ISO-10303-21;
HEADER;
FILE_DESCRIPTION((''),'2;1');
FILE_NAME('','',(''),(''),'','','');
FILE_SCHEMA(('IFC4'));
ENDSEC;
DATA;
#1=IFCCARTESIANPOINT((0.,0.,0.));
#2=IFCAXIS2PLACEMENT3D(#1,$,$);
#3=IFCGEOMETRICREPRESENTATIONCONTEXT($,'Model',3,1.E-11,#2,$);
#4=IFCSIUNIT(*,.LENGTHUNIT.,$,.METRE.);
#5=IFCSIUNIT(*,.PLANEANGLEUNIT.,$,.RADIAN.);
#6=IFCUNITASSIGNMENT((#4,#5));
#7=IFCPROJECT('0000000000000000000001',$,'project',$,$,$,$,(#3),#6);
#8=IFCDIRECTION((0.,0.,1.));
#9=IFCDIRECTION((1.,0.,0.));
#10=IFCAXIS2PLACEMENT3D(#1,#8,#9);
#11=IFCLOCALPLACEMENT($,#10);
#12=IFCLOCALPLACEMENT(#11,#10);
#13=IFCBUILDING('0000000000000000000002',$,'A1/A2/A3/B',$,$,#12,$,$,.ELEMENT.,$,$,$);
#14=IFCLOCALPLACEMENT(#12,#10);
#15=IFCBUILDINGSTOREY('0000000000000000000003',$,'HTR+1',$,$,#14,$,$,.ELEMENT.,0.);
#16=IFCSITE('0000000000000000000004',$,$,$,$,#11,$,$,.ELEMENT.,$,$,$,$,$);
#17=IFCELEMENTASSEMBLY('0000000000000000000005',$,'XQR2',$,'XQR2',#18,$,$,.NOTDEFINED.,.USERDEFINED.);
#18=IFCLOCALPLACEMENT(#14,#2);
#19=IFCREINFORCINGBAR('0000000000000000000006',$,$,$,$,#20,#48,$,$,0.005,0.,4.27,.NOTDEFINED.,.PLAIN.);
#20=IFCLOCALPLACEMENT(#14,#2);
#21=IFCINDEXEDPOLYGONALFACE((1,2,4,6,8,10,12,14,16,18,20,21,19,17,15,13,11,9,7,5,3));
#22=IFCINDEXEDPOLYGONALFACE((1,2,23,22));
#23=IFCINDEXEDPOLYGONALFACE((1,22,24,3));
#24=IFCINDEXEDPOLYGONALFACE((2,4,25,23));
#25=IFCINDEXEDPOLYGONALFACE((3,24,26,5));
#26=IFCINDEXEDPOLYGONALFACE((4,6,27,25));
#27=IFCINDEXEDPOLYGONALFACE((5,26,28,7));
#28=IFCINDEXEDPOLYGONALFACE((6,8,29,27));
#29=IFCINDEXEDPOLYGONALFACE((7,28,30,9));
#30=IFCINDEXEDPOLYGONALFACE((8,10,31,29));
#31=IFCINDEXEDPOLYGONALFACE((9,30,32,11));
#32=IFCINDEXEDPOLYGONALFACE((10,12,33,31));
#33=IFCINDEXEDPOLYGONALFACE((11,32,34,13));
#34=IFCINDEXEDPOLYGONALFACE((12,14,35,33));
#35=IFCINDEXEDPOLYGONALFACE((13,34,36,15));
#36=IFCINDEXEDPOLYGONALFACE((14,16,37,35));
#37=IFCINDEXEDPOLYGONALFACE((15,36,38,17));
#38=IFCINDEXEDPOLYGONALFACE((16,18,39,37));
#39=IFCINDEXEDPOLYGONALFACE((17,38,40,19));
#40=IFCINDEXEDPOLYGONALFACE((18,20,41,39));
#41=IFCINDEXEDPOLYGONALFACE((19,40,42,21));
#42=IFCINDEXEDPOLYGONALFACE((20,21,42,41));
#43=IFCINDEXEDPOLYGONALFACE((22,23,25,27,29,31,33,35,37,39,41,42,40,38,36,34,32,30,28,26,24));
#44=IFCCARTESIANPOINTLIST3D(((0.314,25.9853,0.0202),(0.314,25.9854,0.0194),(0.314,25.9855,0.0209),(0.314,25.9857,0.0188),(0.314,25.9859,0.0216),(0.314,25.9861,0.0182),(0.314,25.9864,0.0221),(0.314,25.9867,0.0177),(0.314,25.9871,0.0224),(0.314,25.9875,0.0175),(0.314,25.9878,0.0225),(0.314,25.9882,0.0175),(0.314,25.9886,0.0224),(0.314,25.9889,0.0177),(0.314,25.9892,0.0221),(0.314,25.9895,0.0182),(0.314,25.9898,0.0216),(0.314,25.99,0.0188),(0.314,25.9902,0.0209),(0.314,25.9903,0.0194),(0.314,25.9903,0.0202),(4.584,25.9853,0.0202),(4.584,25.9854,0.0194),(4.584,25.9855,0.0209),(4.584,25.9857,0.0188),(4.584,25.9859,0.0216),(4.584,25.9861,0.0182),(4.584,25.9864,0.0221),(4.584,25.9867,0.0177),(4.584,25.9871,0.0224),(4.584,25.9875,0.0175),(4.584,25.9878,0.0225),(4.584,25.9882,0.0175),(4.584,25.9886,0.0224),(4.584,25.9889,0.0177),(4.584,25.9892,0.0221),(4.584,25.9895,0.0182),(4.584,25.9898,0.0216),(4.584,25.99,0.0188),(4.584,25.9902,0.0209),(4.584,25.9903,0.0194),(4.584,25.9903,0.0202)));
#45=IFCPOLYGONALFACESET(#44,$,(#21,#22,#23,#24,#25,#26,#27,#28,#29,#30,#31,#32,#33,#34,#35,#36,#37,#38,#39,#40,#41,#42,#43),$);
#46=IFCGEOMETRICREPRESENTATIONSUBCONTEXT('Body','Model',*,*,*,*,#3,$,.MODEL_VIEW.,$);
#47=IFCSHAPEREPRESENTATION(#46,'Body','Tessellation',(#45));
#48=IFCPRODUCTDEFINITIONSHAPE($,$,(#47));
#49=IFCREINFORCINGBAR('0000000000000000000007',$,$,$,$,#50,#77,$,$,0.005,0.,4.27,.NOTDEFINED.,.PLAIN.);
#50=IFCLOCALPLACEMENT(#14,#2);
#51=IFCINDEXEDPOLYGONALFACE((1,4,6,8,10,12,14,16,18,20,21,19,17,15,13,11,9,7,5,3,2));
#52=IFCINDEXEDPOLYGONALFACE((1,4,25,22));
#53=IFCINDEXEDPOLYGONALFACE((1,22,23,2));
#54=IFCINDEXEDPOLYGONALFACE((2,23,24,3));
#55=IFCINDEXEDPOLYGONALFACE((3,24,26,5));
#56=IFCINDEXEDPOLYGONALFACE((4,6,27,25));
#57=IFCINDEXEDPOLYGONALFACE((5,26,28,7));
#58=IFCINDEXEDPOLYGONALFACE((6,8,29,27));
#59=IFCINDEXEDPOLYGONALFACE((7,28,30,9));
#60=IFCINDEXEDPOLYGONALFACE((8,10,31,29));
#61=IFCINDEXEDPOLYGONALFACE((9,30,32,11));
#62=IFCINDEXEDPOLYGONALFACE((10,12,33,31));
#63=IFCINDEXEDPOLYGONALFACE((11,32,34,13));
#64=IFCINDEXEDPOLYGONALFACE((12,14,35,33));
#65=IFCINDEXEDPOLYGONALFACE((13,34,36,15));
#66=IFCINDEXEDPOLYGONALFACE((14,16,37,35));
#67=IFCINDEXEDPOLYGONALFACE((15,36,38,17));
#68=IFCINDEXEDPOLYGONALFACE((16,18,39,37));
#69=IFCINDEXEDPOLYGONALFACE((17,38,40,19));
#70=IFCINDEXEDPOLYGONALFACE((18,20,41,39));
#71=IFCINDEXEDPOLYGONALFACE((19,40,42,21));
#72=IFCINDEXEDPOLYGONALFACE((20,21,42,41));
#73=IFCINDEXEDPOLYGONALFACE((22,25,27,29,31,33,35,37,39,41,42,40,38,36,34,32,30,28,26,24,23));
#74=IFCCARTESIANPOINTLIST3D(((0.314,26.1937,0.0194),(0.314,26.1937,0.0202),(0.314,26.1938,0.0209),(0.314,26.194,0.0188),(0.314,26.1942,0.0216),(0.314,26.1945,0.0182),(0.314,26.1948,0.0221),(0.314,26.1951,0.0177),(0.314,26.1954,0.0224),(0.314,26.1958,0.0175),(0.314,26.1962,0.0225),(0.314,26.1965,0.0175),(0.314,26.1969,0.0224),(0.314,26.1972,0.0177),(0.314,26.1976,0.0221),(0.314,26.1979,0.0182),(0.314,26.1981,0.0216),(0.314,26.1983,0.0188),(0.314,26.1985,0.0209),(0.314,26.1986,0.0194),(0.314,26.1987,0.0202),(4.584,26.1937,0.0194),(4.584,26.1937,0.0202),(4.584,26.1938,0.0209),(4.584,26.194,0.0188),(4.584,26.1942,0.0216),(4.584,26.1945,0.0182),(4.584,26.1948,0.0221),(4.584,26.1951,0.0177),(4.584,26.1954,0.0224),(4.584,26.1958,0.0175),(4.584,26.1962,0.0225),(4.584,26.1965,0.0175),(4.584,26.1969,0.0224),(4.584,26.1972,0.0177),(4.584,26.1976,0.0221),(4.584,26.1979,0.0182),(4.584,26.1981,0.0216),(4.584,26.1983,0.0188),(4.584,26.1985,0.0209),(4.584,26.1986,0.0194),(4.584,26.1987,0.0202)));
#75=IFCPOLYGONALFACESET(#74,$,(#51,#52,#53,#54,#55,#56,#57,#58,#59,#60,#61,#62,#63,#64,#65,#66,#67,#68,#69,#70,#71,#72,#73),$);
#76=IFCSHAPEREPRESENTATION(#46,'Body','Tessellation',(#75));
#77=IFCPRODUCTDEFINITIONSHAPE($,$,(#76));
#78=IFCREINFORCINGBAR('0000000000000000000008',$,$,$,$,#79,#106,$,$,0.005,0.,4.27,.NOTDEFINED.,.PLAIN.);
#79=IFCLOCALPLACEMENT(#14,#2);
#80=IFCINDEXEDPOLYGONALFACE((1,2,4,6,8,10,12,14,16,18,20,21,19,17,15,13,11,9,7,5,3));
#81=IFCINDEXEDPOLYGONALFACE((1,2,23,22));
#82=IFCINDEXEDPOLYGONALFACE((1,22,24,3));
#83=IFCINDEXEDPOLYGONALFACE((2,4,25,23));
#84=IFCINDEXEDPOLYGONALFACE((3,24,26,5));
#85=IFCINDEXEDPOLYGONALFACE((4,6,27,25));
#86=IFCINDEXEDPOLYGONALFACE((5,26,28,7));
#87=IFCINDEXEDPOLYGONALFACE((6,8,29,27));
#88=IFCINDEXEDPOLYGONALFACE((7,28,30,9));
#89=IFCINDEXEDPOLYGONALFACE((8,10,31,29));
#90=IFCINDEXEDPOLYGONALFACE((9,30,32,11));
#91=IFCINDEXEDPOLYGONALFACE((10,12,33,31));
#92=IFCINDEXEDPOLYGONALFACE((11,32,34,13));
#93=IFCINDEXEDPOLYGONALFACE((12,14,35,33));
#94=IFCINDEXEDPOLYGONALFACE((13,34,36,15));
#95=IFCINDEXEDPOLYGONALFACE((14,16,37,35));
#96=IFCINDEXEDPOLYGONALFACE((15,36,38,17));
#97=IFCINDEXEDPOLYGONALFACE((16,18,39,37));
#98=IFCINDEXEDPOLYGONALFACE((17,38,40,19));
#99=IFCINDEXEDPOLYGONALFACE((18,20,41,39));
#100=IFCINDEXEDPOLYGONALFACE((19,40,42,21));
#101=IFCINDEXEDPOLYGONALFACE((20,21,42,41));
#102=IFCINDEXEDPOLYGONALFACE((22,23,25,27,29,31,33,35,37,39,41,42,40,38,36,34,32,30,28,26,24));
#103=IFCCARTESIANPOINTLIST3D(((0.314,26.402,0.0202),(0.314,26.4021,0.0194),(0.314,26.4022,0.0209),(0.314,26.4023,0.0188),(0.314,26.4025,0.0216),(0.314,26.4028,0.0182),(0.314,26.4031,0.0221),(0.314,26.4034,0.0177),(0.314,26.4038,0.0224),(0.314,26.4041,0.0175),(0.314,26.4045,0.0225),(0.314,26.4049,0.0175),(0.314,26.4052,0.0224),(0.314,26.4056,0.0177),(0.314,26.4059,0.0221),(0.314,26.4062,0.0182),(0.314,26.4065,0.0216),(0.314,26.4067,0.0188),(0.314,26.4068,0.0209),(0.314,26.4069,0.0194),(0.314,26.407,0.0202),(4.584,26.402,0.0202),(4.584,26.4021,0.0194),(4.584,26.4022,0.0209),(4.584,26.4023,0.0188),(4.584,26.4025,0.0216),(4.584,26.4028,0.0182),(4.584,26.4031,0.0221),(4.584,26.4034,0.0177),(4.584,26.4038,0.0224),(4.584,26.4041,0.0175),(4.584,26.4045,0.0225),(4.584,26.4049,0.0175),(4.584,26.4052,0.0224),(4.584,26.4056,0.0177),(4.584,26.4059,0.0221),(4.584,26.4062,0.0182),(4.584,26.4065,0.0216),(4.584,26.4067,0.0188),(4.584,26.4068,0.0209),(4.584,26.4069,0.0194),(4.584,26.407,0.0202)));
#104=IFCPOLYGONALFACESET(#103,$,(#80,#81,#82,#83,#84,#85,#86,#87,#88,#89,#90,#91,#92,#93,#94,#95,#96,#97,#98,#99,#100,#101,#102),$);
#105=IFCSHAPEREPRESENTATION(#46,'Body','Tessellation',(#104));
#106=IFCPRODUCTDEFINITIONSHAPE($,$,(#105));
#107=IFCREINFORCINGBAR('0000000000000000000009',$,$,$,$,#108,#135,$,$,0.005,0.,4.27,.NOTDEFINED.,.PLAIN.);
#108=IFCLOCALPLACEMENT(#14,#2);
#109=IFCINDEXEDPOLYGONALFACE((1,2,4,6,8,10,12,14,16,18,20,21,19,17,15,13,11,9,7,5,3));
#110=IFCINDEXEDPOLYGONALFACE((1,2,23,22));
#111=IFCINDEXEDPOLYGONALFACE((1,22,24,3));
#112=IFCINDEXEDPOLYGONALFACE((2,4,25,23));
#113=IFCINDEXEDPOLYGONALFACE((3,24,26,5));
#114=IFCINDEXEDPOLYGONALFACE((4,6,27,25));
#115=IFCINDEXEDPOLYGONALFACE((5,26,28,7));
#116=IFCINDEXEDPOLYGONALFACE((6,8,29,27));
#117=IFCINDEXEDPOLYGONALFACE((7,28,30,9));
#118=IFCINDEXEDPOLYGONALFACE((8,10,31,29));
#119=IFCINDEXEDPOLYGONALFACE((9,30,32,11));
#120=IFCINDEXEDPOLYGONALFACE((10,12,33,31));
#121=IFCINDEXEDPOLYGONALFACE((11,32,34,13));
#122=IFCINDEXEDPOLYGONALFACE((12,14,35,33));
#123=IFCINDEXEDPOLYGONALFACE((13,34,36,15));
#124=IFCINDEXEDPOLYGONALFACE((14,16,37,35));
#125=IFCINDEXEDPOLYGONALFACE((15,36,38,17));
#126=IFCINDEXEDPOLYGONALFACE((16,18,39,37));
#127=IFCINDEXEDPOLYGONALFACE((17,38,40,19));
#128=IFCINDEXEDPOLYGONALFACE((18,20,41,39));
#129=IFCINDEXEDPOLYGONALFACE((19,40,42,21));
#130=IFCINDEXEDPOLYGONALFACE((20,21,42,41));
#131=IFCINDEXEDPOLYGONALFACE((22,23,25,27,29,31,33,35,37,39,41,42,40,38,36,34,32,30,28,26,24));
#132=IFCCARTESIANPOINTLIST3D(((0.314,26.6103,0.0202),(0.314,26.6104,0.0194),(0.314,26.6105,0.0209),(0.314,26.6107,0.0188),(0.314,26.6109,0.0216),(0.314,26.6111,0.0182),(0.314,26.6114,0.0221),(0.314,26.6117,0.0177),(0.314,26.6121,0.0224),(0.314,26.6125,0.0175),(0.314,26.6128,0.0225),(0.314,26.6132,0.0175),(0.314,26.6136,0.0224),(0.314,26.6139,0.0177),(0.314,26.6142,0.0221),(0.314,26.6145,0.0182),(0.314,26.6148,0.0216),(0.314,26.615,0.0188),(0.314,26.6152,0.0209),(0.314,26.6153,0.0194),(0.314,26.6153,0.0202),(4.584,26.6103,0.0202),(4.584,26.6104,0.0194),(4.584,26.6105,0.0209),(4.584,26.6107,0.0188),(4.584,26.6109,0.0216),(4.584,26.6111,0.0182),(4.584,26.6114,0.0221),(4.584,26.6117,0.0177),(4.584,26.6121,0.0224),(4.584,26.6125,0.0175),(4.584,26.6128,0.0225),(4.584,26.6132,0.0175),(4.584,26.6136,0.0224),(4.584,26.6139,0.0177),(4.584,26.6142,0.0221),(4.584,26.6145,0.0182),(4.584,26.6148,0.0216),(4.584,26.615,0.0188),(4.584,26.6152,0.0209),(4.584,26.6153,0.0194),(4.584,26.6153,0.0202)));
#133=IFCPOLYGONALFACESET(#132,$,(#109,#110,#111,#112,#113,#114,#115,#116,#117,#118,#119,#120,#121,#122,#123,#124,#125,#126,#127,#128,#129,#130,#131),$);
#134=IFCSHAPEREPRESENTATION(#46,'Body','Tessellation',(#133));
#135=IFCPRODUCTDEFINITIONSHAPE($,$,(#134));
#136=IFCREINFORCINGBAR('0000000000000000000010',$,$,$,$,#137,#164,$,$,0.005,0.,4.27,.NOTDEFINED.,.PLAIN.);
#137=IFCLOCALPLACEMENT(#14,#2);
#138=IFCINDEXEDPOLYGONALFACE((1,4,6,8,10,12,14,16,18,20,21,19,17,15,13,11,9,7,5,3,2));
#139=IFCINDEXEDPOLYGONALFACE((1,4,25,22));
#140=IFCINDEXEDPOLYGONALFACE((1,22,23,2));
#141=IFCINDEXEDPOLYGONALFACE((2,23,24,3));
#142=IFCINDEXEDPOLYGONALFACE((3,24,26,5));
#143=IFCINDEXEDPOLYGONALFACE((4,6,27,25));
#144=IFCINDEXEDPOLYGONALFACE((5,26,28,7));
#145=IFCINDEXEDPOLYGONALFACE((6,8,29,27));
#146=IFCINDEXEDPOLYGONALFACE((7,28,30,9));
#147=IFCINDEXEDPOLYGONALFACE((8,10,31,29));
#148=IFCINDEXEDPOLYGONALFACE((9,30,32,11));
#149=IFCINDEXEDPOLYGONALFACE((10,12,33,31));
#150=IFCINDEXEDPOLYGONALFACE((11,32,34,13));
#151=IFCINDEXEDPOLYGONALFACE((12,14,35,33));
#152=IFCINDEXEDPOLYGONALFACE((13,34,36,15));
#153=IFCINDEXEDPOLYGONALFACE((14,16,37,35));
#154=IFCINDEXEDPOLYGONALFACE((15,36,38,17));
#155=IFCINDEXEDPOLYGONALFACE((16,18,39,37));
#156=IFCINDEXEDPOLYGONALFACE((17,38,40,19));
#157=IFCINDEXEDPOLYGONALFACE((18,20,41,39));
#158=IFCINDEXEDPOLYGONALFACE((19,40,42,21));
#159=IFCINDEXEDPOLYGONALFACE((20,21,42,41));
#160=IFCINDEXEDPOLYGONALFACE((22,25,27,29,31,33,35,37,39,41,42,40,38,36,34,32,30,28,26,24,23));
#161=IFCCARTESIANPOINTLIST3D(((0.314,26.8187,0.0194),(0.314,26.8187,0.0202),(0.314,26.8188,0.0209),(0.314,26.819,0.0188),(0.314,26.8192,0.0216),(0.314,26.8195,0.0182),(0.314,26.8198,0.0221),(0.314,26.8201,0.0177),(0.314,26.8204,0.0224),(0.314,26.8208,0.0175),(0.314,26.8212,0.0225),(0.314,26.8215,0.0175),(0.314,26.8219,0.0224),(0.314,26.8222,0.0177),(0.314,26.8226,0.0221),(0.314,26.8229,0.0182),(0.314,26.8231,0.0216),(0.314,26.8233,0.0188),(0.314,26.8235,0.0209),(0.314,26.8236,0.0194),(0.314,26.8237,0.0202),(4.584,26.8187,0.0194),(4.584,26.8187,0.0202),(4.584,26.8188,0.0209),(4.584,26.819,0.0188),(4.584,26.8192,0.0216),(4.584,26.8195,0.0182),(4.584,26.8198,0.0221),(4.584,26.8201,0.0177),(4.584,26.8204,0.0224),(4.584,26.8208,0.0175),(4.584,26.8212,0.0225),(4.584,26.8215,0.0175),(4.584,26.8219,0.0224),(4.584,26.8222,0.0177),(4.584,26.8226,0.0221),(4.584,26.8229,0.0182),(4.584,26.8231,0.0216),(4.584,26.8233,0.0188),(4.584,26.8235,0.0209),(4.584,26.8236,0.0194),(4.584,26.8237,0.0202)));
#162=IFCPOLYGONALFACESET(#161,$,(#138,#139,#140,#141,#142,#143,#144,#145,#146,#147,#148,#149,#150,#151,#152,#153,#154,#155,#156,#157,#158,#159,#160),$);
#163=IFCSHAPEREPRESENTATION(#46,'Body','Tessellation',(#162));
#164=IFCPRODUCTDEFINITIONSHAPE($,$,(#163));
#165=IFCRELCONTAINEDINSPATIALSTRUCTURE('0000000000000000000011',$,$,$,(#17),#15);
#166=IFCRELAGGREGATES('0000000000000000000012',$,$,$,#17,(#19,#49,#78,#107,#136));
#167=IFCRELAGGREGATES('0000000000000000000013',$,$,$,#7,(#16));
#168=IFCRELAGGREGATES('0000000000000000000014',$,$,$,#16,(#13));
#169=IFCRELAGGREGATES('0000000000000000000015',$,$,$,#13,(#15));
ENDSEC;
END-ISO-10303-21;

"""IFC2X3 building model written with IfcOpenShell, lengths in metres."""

from ifc_helpers import new_model, entity, si_unit, origin, origin_with_axes, place, context, subcontext, project, spatial, shape, element, aggregate, save


model = new_model("IFC2X3")

# Units and contexts
model_context = context("Model", 3, precision=1e-11, world=origin())
body_context = subcontext(model_context, "Body", "Model", "MODEL_VIEW")
ifc_project = project(units=[si_unit("LENGTHUNIT", "METRE"), si_unit("PLANEANGLEUNIT", "RADIAN")], contexts=[model_context])

# Site, building, storey
site_placement = place(None, origin_with_axes())
site = spatial("IfcSite", under=ifc_project, at=site_placement, CompositionType="ELEMENT")
building_placement = place(site_placement, origin_with_axes())
building = spatial("IfcBuilding", under=site, at=building_placement, Name="A1/A2/A3/B", CompositionType="ELEMENT")
storey_placement = place(building_placement, origin_with_axes())
storey = spatial("IfcBuildingStorey", under=building, at=storey_placement, Name="HTR+1", CompositionType="ELEMENT", Elevation=0.0)

# Element assembly, reinforcing bars
assembly_1_placement = place(storey_placement, origin_with_axes())
assembly_1 = element("IfcElementAssembly", 1, at=assembly_1_placement, inside=storey, Name="XQR2", ObjectType="XQR2", AssemblyPlace="NOTDEFINED", PredefinedType="USERDEFINED")
reinforcing_bar_1_placement = place(assembly_1_placement, origin_with_axes())
reinforcing_bar_1 = element("IfcReinforcingBar", 2, at=reinforcing_bar_1_placement, BarLength=4.27, BarRole="NOTDEFINED", BarSurface="PLAIN", CrossSectionArea=0.0, NominalDiameter=0.005, shapes=[
    shape(body_context, "Body", "AdvancedSweptSolid", [entity("IfcSweptDiskSolid", entity("IfcPolyline", [entity("IfcCartesianPoint", [0.314, 25.9878, 0.02]), entity("IfcCartesianPoint", [4.584, 25.9878, 0.02])]), 0.0025, None, 0.0, 4.27)]),
    shape(body_context, "Body", "AdvancedSweptSolid", [entity("IfcSweptDiskSolid", entity("IfcPolyline", [entity("IfcCartesianPoint", [0.314, 25.9878, 0.02]), entity("IfcCartesianPoint", [4.584, 25.9878, 0.02])]), 0.0025, None, 0.0, 4.27)]),
])
reinforcing_bar_2_placement = place(assembly_1_placement, origin_with_axes())
reinforcing_bar_2 = element("IfcReinforcingBar", 3, at=reinforcing_bar_2_placement, BarLength=4.27, BarRole="NOTDEFINED", BarSurface="PLAIN", CrossSectionArea=0.0, NominalDiameter=0.005, shapes=[
    shape(body_context, "Body", "AdvancedSweptSolid", [entity("IfcSweptDiskSolid", entity("IfcPolyline", [entity("IfcCartesianPoint", [0.314, 26.1962, 0.02]), entity("IfcCartesianPoint", [4.584, 26.1962, 0.02])]), 0.0025, None, 0.0, 4.27)]),
    shape(body_context, "Body", "AdvancedSweptSolid", [entity("IfcSweptDiskSolid", entity("IfcPolyline", [entity("IfcCartesianPoint", [0.314, 26.1962, 0.02]), entity("IfcCartesianPoint", [4.584, 26.1962, 0.02])]), 0.0025, None, 0.0, 4.27)]),
])
reinforcing_bar_3_placement = place(assembly_1_placement, origin_with_axes())
reinforcing_bar_3 = element("IfcReinforcingBar", 4, at=reinforcing_bar_3_placement, BarLength=4.27, BarRole="NOTDEFINED", BarSurface="PLAIN", CrossSectionArea=0.0, NominalDiameter=0.005, shapes=[
    shape(body_context, "Body", "AdvancedSweptSolid", [entity("IfcSweptDiskSolid", entity("IfcPolyline", [entity("IfcCartesianPoint", [0.314, 26.4045, 0.02]), entity("IfcCartesianPoint", [4.584, 26.4045, 0.02])]), 0.0025, None, 0.0, 4.27)]),
    shape(body_context, "Body", "AdvancedSweptSolid", [entity("IfcSweptDiskSolid", entity("IfcPolyline", [entity("IfcCartesianPoint", [0.314, 26.4045, 0.02]), entity("IfcCartesianPoint", [4.584, 26.4045, 0.02])]), 0.0025, None, 0.0, 4.27)]),
])
reinforcing_bar_4_placement = place(assembly_1_placement, origin_with_axes())
reinforcing_bar_4 = element("IfcReinforcingBar", 5, at=reinforcing_bar_4_placement, BarLength=4.27, BarRole="NOTDEFINED", BarSurface="PLAIN", CrossSectionArea=0.0, NominalDiameter=0.005, shapes=[
    shape(body_context, "Body", "AdvancedSweptSolid", [entity("IfcSweptDiskSolid", entity("IfcPolyline", [entity("IfcCartesianPoint", [0.314, 26.6128, 0.02]), entity("IfcCartesianPoint", [4.584, 26.6128, 0.02])]), 0.0025, None, 0.0, 4.27)]),
    shape(body_context, "Body", "AdvancedSweptSolid", [entity("IfcSweptDiskSolid", entity("IfcPolyline", [entity("IfcCartesianPoint", [0.314, 26.6128, 0.02]), entity("IfcCartesianPoint", [4.584, 26.6128, 0.02])]), 0.0025, None, 0.0, 4.27)]),
])
reinforcing_bar_5_placement = place(assembly_1_placement, origin_with_axes())
reinforcing_bar_5 = element("IfcReinforcingBar", 6, at=reinforcing_bar_5_placement, BarLength=4.27, BarRole="NOTDEFINED", BarSurface="PLAIN", CrossSectionArea=0.0, NominalDiameter=0.005, shapes=[
    shape(body_context, "Body", "AdvancedSweptSolid", [entity("IfcSweptDiskSolid", entity("IfcPolyline", [entity("IfcCartesianPoint", [0.314, 26.8212, 0.02]), entity("IfcCartesianPoint", [4.584, 26.8212, 0.02])]), 0.0025, None, 0.0, 4.27)]),
    shape(body_context, "Body", "AdvancedSweptSolid", [entity("IfcSweptDiskSolid", entity("IfcPolyline", [entity("IfcCartesianPoint", [0.314, 26.8212, 0.02]), entity("IfcCartesianPoint", [4.584, 26.8212, 0.02])]), 0.0025, None, 0.0, 4.27)]),
])
aggregate(assembly_1, [reinforcing_bar_1, reinforcing_bar_2, reinforcing_bar_3, reinforcing_bar_4, reinforcing_bar_5])

save(model, "model.ifc")
